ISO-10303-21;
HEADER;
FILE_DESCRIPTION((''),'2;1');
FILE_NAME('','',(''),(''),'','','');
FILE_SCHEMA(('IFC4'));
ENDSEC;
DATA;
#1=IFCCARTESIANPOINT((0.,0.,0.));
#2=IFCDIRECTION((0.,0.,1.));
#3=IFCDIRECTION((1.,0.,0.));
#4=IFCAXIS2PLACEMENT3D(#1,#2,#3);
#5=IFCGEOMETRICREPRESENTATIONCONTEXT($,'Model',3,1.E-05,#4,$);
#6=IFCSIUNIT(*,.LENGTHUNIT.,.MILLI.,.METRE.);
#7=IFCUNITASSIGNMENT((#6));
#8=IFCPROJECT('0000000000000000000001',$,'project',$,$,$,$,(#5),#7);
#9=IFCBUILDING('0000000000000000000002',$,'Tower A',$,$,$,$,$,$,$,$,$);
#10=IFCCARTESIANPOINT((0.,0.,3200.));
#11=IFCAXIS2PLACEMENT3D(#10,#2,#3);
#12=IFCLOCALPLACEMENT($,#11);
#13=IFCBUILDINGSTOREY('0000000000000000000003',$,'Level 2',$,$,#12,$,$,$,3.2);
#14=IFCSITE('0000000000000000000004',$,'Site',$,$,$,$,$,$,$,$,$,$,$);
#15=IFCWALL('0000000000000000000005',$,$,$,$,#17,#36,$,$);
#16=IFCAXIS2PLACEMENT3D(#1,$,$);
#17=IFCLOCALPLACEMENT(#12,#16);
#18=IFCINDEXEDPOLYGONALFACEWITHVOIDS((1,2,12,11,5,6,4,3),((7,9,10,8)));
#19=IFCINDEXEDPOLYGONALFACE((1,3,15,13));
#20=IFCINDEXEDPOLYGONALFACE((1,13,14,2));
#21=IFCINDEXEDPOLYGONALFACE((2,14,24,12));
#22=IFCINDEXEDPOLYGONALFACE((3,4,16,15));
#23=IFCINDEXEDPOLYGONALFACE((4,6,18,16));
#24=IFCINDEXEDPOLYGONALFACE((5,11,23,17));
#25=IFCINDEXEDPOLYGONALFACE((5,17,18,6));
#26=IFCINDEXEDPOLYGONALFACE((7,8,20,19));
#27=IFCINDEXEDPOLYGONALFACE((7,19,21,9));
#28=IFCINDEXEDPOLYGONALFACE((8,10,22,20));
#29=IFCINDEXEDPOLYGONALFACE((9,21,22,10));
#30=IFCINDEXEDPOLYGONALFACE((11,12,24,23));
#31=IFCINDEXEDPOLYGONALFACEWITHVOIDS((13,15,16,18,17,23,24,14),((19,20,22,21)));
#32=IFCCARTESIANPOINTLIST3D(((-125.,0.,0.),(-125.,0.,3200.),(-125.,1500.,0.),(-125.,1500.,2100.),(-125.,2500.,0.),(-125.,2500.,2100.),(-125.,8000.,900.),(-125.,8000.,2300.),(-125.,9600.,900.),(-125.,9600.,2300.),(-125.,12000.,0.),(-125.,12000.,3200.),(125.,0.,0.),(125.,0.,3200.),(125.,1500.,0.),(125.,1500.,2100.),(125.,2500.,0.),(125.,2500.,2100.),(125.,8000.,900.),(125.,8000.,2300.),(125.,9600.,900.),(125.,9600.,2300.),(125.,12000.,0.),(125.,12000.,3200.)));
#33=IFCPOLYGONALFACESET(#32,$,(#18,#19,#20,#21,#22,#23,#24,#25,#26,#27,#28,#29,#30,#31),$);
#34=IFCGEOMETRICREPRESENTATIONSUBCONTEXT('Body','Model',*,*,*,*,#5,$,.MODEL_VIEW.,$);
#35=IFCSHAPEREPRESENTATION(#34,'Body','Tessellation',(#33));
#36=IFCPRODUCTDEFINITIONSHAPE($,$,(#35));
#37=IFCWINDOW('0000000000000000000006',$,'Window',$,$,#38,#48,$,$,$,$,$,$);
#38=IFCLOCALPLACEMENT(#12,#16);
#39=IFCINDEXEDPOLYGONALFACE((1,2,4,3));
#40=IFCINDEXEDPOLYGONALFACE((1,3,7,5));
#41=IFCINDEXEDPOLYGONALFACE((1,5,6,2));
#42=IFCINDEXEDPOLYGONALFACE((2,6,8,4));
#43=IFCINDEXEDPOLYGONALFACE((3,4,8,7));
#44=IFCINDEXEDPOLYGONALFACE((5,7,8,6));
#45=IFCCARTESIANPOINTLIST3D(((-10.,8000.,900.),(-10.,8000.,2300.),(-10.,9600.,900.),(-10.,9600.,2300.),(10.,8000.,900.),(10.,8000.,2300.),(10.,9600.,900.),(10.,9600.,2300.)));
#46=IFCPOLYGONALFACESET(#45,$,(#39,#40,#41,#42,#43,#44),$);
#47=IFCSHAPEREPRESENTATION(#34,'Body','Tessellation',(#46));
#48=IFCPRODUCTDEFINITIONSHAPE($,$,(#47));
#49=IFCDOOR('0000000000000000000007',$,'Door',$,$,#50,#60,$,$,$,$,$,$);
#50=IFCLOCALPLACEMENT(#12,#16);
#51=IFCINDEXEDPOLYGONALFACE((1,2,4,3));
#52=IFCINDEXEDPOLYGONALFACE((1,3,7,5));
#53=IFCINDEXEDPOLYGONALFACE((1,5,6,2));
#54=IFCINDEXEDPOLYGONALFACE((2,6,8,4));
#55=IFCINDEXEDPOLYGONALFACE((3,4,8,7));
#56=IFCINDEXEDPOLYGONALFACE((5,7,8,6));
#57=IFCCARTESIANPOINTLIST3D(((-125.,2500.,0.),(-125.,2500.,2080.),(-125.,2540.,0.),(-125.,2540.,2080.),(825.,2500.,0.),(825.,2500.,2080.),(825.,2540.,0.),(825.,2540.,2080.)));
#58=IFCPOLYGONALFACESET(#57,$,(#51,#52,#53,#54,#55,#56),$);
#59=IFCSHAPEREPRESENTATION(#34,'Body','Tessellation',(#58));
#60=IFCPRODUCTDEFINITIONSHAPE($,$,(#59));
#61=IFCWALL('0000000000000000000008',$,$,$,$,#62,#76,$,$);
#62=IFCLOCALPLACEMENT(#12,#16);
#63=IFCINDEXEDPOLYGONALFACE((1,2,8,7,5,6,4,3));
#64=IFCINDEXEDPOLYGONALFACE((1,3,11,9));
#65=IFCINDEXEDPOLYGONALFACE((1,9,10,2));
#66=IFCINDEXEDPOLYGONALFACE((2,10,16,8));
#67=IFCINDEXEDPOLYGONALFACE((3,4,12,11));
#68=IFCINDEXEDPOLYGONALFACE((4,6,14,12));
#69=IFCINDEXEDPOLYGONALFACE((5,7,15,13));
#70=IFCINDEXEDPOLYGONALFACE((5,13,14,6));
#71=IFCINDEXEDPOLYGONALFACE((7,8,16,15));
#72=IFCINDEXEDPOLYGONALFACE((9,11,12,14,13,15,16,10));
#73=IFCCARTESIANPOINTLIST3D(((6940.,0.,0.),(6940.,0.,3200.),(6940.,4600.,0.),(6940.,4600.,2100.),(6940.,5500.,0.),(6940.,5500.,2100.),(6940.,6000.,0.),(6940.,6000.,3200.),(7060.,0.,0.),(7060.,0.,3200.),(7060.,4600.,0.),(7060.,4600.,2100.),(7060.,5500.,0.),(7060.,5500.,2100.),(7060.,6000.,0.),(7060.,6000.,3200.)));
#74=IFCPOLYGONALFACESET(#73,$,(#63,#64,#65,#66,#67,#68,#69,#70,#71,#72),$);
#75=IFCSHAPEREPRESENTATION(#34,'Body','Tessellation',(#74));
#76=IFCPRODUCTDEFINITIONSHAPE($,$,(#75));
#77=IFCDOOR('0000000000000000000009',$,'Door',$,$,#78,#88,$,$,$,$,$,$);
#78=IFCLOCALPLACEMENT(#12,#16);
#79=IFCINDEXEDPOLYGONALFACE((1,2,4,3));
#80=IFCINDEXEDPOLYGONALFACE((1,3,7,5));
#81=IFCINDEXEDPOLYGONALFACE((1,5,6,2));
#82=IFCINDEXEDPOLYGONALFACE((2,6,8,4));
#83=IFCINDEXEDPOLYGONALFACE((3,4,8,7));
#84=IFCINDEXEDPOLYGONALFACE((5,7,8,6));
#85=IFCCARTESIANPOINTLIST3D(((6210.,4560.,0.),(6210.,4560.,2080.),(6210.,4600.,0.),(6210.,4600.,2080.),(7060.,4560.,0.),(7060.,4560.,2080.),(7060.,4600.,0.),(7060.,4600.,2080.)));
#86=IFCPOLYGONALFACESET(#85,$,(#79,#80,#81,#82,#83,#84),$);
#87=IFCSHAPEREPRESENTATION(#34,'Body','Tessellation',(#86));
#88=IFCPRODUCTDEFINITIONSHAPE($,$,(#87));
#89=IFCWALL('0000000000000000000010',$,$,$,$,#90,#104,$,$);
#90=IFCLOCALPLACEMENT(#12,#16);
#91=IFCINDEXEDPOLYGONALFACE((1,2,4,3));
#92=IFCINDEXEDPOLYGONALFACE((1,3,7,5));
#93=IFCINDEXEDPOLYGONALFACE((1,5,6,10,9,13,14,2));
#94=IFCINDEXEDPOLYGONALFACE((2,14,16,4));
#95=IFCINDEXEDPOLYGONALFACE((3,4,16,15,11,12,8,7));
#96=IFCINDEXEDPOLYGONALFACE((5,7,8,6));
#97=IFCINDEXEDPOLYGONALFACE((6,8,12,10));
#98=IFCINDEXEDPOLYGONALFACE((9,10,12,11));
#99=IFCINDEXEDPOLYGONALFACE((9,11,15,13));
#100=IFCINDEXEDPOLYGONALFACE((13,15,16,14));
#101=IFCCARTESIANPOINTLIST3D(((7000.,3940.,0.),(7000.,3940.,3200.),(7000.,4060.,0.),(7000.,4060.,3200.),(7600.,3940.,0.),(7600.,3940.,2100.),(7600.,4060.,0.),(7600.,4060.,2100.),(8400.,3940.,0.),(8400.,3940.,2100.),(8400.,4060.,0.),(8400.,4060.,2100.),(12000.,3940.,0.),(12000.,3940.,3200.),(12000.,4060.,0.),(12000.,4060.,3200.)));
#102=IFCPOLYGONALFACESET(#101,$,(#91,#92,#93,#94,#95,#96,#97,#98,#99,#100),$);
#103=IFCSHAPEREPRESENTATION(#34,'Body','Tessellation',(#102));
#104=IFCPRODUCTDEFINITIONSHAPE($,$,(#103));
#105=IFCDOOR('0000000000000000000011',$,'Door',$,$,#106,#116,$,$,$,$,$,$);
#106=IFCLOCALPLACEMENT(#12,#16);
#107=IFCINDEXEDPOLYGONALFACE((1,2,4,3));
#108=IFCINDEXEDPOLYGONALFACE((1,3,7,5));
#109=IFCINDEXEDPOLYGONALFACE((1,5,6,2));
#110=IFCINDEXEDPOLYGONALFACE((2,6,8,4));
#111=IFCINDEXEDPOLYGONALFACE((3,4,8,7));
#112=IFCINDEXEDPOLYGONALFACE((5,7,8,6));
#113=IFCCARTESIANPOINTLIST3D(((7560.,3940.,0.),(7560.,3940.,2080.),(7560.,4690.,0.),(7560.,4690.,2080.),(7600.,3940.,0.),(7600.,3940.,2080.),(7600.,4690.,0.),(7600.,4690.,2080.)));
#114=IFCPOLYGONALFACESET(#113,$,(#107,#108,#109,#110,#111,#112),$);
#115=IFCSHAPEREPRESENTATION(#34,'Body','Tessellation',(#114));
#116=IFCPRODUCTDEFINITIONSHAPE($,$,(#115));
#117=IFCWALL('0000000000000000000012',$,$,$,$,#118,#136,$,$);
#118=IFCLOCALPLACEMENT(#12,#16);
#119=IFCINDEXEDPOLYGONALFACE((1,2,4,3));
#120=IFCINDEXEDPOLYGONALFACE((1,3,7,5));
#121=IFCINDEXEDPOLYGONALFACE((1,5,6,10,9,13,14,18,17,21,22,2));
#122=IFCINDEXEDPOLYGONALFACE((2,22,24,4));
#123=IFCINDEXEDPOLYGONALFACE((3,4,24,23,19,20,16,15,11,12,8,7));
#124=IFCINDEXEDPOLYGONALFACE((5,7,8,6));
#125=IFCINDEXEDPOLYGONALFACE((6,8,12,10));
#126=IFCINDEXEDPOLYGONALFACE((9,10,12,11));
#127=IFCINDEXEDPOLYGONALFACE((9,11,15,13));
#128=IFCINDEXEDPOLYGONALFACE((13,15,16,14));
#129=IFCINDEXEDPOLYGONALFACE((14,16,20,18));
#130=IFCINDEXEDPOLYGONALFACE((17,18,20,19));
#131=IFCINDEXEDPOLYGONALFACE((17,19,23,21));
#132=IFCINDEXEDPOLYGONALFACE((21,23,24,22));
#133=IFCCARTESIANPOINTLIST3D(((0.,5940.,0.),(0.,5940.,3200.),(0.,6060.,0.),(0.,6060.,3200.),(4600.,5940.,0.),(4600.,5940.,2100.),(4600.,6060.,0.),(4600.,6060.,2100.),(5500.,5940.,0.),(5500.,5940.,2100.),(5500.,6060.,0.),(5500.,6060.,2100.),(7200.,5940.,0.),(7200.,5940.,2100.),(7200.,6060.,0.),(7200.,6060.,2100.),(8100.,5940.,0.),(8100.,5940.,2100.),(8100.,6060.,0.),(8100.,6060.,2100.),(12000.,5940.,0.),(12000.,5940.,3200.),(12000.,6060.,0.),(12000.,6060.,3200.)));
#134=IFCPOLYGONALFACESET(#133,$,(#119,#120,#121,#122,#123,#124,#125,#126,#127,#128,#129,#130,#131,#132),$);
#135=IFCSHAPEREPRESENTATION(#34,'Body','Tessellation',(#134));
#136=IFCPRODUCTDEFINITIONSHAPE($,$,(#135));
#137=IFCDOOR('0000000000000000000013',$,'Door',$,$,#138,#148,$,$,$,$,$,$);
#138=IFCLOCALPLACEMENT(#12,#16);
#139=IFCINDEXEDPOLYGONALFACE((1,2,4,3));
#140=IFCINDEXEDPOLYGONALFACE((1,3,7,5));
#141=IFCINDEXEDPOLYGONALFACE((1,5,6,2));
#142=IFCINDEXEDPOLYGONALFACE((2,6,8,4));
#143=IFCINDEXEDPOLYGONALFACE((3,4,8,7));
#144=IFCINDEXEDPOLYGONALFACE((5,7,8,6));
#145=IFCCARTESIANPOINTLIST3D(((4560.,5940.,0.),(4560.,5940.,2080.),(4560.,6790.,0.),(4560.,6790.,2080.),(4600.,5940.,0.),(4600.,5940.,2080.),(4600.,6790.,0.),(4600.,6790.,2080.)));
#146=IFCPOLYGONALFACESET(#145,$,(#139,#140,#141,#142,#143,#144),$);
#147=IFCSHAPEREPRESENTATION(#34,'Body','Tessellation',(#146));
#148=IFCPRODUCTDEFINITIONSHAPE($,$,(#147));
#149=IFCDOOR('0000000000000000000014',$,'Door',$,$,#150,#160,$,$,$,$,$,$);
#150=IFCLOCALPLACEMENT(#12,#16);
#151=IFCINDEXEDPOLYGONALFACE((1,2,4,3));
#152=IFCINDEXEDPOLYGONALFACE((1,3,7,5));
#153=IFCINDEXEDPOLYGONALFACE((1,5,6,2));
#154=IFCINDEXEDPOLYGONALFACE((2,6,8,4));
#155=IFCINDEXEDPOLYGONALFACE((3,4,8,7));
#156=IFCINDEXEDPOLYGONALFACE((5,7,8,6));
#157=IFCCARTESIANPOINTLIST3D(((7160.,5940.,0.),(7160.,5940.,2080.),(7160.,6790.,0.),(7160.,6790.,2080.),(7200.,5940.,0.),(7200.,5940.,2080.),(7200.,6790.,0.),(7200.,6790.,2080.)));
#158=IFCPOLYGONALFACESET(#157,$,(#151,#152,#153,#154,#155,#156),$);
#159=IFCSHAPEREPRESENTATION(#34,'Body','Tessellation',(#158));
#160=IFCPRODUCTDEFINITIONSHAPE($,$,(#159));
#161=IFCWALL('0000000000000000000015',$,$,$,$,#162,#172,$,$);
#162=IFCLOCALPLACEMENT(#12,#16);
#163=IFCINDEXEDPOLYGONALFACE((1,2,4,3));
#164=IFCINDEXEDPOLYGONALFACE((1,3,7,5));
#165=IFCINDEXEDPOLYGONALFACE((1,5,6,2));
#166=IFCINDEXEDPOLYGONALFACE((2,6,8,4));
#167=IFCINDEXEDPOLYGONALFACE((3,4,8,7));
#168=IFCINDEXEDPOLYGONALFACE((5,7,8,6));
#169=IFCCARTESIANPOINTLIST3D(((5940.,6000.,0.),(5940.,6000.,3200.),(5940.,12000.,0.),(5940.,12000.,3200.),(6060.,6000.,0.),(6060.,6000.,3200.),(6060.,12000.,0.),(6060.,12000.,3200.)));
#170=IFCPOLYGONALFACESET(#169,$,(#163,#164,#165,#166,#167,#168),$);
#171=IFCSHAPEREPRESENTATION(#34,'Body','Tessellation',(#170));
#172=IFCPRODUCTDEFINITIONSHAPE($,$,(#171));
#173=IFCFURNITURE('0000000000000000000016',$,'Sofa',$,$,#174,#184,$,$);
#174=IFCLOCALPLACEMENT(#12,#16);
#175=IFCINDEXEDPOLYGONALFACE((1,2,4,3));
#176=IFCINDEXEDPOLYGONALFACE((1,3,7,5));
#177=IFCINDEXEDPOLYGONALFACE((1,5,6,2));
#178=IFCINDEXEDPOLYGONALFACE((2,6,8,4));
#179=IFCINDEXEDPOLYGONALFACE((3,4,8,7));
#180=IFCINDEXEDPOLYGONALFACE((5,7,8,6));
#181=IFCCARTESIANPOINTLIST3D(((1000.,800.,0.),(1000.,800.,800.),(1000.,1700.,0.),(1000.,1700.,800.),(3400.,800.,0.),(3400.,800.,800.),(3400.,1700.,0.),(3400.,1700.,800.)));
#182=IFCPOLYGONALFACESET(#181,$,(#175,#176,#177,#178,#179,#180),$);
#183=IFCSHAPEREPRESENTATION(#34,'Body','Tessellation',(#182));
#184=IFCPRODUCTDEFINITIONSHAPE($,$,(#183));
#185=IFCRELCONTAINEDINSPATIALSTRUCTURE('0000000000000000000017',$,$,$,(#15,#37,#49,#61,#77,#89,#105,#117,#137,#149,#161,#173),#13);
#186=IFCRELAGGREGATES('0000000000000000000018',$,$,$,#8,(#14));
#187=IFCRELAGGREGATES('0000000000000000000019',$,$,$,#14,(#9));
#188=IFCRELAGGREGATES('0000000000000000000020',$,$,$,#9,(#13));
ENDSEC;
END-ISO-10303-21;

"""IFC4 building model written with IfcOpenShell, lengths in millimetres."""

from ifc_helpers import new_model, si_unit, frame, origin_with_axes, place, context, subcontext, project, spatial, indexed_curve, outline, extrude, element, fill, save


model = new_model("IFC4")

# Units and contexts
model_context = context("Model", 3, precision=1e-05, world=origin_with_axes())
body_context = subcontext(model_context, "Body", "Model", "MODEL_VIEW")
ifc_project = project(units=[si_unit("LENGTHUNIT", "METRE", prefix="MILLI")], contexts=[model_context])

# Site, building, storey
site = spatial("IfcSite", under=ifc_project, Name="Site")
building = spatial("IfcBuilding", under=site, Name="Tower A")
storey_placement = place(None, frame((0.0, 0.0, 3200.0), z_axis=(0.0, 0.0, 1.0), x_axis=(1.0, 0.0, 0.0)))
storey = spatial("IfcBuildingStorey", under=building, at=storey_placement, Name="Level 2", Elevation=3.2)

# Wall, openings, window, door
wall_1_placement = place(storey_placement, frame((-125.0, 12000.0, 0.0), z_axis=(0.0, 0.0, 1.0), x_axis=(0.0, -1.0, 0.0)))
wall_1 = element("IfcWall", 1, at=wall_1_placement, inside=storey, context=body_context, shape_type="SweptSolid", body=[
    extrude(outline(indexed_curve([(0.0, 0.0), (0.0, 250.0), (12000.0, 250.0), (12000.0, 0.0), (0.0, 0.0)], self_intersect=False)), origin_with_axes(), (0.0, 0.0, 1.0), 3200.0),
])
opening_1_placement = place(wall_1_placement, frame((2400.0, 0.0, 900.0), z_axis=(0.0, 0.0, 1.0), x_axis=(1.0, 0.0, 0.0)))
opening_1 = element("IfcOpeningElement", 2, at=opening_1_placement, cuts=wall_1, context=body_context, shape_type="SweptSolid", body=[
    extrude(outline(indexed_curve([(0.0, 0.0), (0.0, 250.0), (1600.0, 250.0), (1600.0, 0.0), (0.0, 0.0)], self_intersect=False)), origin_with_axes(), (0.0, 0.0, 1.0), 1400.0),
])
opening_2_placement = place(wall_1_placement, frame((9500.0, 0.0, 0.0), z_axis=(0.0, 0.0, 1.0), x_axis=(1.0, 0.0, 0.0)))
opening_2 = element("IfcOpeningElement", 3, at=opening_2_placement, cuts=wall_1, context=body_context, shape_type="SweptSolid", body=[
    extrude(outline(indexed_curve([(0.0, 0.0), (0.0, 250.0), (1000.0, 250.0), (1000.0, 0.0), (0.0, 0.0)], self_intersect=False)), origin_with_axes(), (0.0, 0.0, 1.0), 2100.0),
])
window_1_placement = place(storey_placement, frame((-10.0, 9600.0, 900.0), z_axis=(0.0, 0.0, 1.0), x_axis=(0.0, -1.0, 0.0)))
window_1 = element("IfcWindow", 4, at=window_1_placement, inside=storey, Name="Window", context=body_context, shape_type="SweptSolid", body=[
    extrude(outline(indexed_curve([(0.0, 0.0), (0.0, 20.0), (1600.0, 20.0), (1600.0, 0.0), (0.0, 0.0)], self_intersect=False)), origin_with_axes(), (0.0, 0.0, 1.0), 1400.0),
])
fill(opening_1, window_1)
door_1_placement = place(storey_placement, frame((-125.0, 2500.0, 0.0), z_axis=(0.0, 0.0, 1.0), x_axis=(1.0, 0.0, 0.0)))
door_1 = element("IfcDoor", 5, at=door_1_placement, inside=storey, Name="Door", context=body_context, shape_type="SweptSolid", body=[
    extrude(outline(indexed_curve([(0.0, 0.0), (0.0, 40.0), (950.0, 40.0), (950.0, 0.0), (0.0, 0.0)], self_intersect=False)), origin_with_axes(), (0.0, 0.0, 1.0), 2080.0),
])
fill(opening_2, door_1)

# Walls, openings, doors
wall_2_placement = place(storey_placement, frame((7060.0, 0.0, 0.0), z_axis=(0.0, 0.0, 1.0), x_axis=(0.0, 1.0, 0.0)))
wall_2 = element("IfcWall", 6, at=wall_2_placement, inside=storey, context=body_context, shape_type="SweptSolid", body=[
    extrude(outline(indexed_curve([(0.0, 0.0), (0.0, 120.0), (6000.0, 120.0), (6000.0, 0.0), (0.0, 0.0)], self_intersect=False)), origin_with_axes(), (0.0, 0.0, 1.0), 3200.0),
])
opening_3_placement = place(wall_2_placement, frame((4600.0, 0.0, 0.0), z_axis=(0.0, 0.0, 1.0), x_axis=(1.0, 0.0, 0.0)))
opening_3 = element("IfcOpeningElement", 7, at=opening_3_placement, cuts=wall_2, context=body_context, shape_type="SweptSolid", body=[
    extrude(outline(indexed_curve([(0.0, 0.0), (0.0, 120.0), (900.0, 120.0), (900.0, 0.0), (0.0, 0.0)], self_intersect=False)), origin_with_axes(), (0.0, 0.0, 1.0), 2100.0),
])
door_2_placement = place(storey_placement, frame((7060.0, 4600.0, 0.0), z_axis=(0.0, 0.0, 1.0), x_axis=(-1.0, 0.0, 0.0)))
door_2 = element("IfcDoor", 8, at=door_2_placement, inside=storey, Name="Door", context=body_context, shape_type="SweptSolid", body=[
    extrude(outline(indexed_curve([(0.0, 0.0), (0.0, 40.0), (850.0, 40.0), (850.0, 0.0), (0.0, 0.0)], self_intersect=False)), origin_with_axes(), (0.0, 0.0, 1.0), 2080.0),
])
fill(opening_3, door_2)
wall_3_placement = place(storey_placement, frame((7000.0, 3940.0, 0.0), z_axis=(0.0, 0.0, 1.0), x_axis=(1.0, 0.0, 0.0)))
wall_3 = element("IfcWall", 9, at=wall_3_placement, inside=storey, context=body_context, shape_type="SweptSolid", body=[
    extrude(outline(indexed_curve([(0.0, 0.0), (0.0, 120.0), (5000.0, 120.0), (5000.0, 0.0), (0.0, 0.0)], self_intersect=False)), origin_with_axes(), (0.0, 0.0, 1.0), 3200.0),
])
opening_4_placement = place(wall_3_placement, frame((600.0, 0.0, 0.0), z_axis=(0.0, 0.0, 1.0), x_axis=(1.0, 0.0, 0.0)))
opening_4 = element("IfcOpeningElement", 10, at=opening_4_placement, cuts=wall_3, context=body_context, shape_type="SweptSolid", body=[
    extrude(outline(indexed_curve([(0.0, 0.0), (0.0, 120.0), (800.0, 120.0), (800.0, 0.0), (0.0, 0.0)], self_intersect=False)), origin_with_axes(), (0.0, 0.0, 1.0), 2100.0),
])
door_3_placement = place(storey_placement, frame((7600.0, 3940.0, 0.0), z_axis=(0.0, 0.0, 1.0), x_axis=(0.0, 1.0, 0.0)))
door_3 = element("IfcDoor", 11, at=door_3_placement, inside=storey, Name="Door", context=body_context, shape_type="SweptSolid", body=[
    extrude(outline(indexed_curve([(0.0, 0.0), (0.0, 40.0), (750.0, 40.0), (750.0, 0.0), (0.0, 0.0)], self_intersect=False)), origin_with_axes(), (0.0, 0.0, 1.0), 2080.0),
])
fill(opening_4, door_3)

# Wall, openings, doors
wall_4_placement = place(storey_placement, frame((0.0, 5940.0, 0.0), z_axis=(0.0, 0.0, 1.0), x_axis=(1.0, 0.0, 0.0)))
wall_4 = element("IfcWall", 12, at=wall_4_placement, inside=storey, context=body_context, shape_type="SweptSolid", body=[
    extrude(outline(indexed_curve([(0.0, 0.0), (0.0, 120.0), (12000.0, 120.0), (12000.0, 0.0), (0.0, 0.0)], self_intersect=False)), origin_with_axes(), (0.0, 0.0, 1.0), 3200.0),
])
opening_5_placement = place(wall_4_placement, frame((4600.0, 0.0, 0.0), z_axis=(0.0, 0.0, 1.0), x_axis=(1.0, 0.0, 0.0)))
opening_5 = element("IfcOpeningElement", 13, at=opening_5_placement, cuts=wall_4, context=body_context, shape_type="SweptSolid", body=[
    extrude(outline(indexed_curve([(0.0, 0.0), (0.0, 120.0), (900.0, 120.0), (900.0, 0.0), (0.0, 0.0)], self_intersect=False)), origin_with_axes(), (0.0, 0.0, 1.0), 2100.0),
])
opening_6_placement = place(wall_4_placement, frame((7200.0, 0.0, 0.0), z_axis=(0.0, 0.0, 1.0), x_axis=(1.0, 0.0, 0.0)))
opening_6 = element("IfcOpeningElement", 14, at=opening_6_placement, cuts=wall_4, context=body_context, shape_type="SweptSolid", body=[
    extrude(outline(indexed_curve([(0.0, 0.0), (0.0, 120.0), (900.0, 120.0), (900.0, 0.0), (0.0, 0.0)], self_intersect=False)), origin_with_axes(), (0.0, 0.0, 1.0), 2100.0),
])
door_4_placement = place(storey_placement, frame((4600.0, 5940.0, 0.0), z_axis=(0.0, 0.0, 1.0), x_axis=(0.0, 1.0, 0.0)))
door_4 = element("IfcDoor", 15, at=door_4_placement, inside=storey, Name="Door", context=body_context, shape_type="SweptSolid", body=[
    extrude(outline(indexed_curve([(0.0, 0.0), (0.0, 40.0), (850.0, 40.0), (850.0, 0.0), (0.0, 0.0)], self_intersect=False)), origin_with_axes(), (0.0, 0.0, 1.0), 2080.0),
])
fill(opening_5, door_4)
door_5_placement = place(storey_placement, frame((7200.0, 5940.0, 0.0), z_axis=(0.0, 0.0, 1.0), x_axis=(0.0, 1.0, 0.0)))
door_5 = element("IfcDoor", 16, at=door_5_placement, inside=storey, Name="Door", context=body_context, shape_type="SweptSolid", body=[
    extrude(outline(indexed_curve([(0.0, 0.0), (0.0, 40.0), (850.0, 40.0), (850.0, 0.0), (0.0, 0.0)], self_intersect=False)), origin_with_axes(), (0.0, 0.0, 1.0), 2080.0),
])
fill(opening_6, door_5)

# Wall
wall_5_placement = place(storey_placement, frame((6060.0, 6000.0, 0.0), z_axis=(0.0, 0.0, 1.0), x_axis=(0.0, 1.0, 0.0)))
element("IfcWall", 17, at=wall_5_placement, inside=storey, context=body_context, shape_type="SweptSolid", body=[
    extrude(outline(indexed_curve([(0.0, 0.0), (0.0, 120.0), (6000.0, 120.0), (6000.0, 0.0), (0.0, 0.0)], self_intersect=False)), origin_with_axes(), (0.0, 0.0, 1.0), 3200.0),
])

# Furniture
furniture_1_placement = place(storey_placement, frame((1000.0, 800.0, 0.0), z_axis=(0.0, 0.0, 1.0), x_axis=(1.0, 0.0, 0.0)))
element("IfcFurniture", 18, at=furniture_1_placement, inside=storey, Name="Sofa", context=body_context, shape_type="SweptSolid", body=[
    extrude(outline(indexed_curve([(0.0, 0.0), (2400.0, 0.0), (2400.0, 900.0), (0.0, 900.0)])), None, (0.0, 0.0, 1.0), 800.0),
])

save(model, "model.ifc")
